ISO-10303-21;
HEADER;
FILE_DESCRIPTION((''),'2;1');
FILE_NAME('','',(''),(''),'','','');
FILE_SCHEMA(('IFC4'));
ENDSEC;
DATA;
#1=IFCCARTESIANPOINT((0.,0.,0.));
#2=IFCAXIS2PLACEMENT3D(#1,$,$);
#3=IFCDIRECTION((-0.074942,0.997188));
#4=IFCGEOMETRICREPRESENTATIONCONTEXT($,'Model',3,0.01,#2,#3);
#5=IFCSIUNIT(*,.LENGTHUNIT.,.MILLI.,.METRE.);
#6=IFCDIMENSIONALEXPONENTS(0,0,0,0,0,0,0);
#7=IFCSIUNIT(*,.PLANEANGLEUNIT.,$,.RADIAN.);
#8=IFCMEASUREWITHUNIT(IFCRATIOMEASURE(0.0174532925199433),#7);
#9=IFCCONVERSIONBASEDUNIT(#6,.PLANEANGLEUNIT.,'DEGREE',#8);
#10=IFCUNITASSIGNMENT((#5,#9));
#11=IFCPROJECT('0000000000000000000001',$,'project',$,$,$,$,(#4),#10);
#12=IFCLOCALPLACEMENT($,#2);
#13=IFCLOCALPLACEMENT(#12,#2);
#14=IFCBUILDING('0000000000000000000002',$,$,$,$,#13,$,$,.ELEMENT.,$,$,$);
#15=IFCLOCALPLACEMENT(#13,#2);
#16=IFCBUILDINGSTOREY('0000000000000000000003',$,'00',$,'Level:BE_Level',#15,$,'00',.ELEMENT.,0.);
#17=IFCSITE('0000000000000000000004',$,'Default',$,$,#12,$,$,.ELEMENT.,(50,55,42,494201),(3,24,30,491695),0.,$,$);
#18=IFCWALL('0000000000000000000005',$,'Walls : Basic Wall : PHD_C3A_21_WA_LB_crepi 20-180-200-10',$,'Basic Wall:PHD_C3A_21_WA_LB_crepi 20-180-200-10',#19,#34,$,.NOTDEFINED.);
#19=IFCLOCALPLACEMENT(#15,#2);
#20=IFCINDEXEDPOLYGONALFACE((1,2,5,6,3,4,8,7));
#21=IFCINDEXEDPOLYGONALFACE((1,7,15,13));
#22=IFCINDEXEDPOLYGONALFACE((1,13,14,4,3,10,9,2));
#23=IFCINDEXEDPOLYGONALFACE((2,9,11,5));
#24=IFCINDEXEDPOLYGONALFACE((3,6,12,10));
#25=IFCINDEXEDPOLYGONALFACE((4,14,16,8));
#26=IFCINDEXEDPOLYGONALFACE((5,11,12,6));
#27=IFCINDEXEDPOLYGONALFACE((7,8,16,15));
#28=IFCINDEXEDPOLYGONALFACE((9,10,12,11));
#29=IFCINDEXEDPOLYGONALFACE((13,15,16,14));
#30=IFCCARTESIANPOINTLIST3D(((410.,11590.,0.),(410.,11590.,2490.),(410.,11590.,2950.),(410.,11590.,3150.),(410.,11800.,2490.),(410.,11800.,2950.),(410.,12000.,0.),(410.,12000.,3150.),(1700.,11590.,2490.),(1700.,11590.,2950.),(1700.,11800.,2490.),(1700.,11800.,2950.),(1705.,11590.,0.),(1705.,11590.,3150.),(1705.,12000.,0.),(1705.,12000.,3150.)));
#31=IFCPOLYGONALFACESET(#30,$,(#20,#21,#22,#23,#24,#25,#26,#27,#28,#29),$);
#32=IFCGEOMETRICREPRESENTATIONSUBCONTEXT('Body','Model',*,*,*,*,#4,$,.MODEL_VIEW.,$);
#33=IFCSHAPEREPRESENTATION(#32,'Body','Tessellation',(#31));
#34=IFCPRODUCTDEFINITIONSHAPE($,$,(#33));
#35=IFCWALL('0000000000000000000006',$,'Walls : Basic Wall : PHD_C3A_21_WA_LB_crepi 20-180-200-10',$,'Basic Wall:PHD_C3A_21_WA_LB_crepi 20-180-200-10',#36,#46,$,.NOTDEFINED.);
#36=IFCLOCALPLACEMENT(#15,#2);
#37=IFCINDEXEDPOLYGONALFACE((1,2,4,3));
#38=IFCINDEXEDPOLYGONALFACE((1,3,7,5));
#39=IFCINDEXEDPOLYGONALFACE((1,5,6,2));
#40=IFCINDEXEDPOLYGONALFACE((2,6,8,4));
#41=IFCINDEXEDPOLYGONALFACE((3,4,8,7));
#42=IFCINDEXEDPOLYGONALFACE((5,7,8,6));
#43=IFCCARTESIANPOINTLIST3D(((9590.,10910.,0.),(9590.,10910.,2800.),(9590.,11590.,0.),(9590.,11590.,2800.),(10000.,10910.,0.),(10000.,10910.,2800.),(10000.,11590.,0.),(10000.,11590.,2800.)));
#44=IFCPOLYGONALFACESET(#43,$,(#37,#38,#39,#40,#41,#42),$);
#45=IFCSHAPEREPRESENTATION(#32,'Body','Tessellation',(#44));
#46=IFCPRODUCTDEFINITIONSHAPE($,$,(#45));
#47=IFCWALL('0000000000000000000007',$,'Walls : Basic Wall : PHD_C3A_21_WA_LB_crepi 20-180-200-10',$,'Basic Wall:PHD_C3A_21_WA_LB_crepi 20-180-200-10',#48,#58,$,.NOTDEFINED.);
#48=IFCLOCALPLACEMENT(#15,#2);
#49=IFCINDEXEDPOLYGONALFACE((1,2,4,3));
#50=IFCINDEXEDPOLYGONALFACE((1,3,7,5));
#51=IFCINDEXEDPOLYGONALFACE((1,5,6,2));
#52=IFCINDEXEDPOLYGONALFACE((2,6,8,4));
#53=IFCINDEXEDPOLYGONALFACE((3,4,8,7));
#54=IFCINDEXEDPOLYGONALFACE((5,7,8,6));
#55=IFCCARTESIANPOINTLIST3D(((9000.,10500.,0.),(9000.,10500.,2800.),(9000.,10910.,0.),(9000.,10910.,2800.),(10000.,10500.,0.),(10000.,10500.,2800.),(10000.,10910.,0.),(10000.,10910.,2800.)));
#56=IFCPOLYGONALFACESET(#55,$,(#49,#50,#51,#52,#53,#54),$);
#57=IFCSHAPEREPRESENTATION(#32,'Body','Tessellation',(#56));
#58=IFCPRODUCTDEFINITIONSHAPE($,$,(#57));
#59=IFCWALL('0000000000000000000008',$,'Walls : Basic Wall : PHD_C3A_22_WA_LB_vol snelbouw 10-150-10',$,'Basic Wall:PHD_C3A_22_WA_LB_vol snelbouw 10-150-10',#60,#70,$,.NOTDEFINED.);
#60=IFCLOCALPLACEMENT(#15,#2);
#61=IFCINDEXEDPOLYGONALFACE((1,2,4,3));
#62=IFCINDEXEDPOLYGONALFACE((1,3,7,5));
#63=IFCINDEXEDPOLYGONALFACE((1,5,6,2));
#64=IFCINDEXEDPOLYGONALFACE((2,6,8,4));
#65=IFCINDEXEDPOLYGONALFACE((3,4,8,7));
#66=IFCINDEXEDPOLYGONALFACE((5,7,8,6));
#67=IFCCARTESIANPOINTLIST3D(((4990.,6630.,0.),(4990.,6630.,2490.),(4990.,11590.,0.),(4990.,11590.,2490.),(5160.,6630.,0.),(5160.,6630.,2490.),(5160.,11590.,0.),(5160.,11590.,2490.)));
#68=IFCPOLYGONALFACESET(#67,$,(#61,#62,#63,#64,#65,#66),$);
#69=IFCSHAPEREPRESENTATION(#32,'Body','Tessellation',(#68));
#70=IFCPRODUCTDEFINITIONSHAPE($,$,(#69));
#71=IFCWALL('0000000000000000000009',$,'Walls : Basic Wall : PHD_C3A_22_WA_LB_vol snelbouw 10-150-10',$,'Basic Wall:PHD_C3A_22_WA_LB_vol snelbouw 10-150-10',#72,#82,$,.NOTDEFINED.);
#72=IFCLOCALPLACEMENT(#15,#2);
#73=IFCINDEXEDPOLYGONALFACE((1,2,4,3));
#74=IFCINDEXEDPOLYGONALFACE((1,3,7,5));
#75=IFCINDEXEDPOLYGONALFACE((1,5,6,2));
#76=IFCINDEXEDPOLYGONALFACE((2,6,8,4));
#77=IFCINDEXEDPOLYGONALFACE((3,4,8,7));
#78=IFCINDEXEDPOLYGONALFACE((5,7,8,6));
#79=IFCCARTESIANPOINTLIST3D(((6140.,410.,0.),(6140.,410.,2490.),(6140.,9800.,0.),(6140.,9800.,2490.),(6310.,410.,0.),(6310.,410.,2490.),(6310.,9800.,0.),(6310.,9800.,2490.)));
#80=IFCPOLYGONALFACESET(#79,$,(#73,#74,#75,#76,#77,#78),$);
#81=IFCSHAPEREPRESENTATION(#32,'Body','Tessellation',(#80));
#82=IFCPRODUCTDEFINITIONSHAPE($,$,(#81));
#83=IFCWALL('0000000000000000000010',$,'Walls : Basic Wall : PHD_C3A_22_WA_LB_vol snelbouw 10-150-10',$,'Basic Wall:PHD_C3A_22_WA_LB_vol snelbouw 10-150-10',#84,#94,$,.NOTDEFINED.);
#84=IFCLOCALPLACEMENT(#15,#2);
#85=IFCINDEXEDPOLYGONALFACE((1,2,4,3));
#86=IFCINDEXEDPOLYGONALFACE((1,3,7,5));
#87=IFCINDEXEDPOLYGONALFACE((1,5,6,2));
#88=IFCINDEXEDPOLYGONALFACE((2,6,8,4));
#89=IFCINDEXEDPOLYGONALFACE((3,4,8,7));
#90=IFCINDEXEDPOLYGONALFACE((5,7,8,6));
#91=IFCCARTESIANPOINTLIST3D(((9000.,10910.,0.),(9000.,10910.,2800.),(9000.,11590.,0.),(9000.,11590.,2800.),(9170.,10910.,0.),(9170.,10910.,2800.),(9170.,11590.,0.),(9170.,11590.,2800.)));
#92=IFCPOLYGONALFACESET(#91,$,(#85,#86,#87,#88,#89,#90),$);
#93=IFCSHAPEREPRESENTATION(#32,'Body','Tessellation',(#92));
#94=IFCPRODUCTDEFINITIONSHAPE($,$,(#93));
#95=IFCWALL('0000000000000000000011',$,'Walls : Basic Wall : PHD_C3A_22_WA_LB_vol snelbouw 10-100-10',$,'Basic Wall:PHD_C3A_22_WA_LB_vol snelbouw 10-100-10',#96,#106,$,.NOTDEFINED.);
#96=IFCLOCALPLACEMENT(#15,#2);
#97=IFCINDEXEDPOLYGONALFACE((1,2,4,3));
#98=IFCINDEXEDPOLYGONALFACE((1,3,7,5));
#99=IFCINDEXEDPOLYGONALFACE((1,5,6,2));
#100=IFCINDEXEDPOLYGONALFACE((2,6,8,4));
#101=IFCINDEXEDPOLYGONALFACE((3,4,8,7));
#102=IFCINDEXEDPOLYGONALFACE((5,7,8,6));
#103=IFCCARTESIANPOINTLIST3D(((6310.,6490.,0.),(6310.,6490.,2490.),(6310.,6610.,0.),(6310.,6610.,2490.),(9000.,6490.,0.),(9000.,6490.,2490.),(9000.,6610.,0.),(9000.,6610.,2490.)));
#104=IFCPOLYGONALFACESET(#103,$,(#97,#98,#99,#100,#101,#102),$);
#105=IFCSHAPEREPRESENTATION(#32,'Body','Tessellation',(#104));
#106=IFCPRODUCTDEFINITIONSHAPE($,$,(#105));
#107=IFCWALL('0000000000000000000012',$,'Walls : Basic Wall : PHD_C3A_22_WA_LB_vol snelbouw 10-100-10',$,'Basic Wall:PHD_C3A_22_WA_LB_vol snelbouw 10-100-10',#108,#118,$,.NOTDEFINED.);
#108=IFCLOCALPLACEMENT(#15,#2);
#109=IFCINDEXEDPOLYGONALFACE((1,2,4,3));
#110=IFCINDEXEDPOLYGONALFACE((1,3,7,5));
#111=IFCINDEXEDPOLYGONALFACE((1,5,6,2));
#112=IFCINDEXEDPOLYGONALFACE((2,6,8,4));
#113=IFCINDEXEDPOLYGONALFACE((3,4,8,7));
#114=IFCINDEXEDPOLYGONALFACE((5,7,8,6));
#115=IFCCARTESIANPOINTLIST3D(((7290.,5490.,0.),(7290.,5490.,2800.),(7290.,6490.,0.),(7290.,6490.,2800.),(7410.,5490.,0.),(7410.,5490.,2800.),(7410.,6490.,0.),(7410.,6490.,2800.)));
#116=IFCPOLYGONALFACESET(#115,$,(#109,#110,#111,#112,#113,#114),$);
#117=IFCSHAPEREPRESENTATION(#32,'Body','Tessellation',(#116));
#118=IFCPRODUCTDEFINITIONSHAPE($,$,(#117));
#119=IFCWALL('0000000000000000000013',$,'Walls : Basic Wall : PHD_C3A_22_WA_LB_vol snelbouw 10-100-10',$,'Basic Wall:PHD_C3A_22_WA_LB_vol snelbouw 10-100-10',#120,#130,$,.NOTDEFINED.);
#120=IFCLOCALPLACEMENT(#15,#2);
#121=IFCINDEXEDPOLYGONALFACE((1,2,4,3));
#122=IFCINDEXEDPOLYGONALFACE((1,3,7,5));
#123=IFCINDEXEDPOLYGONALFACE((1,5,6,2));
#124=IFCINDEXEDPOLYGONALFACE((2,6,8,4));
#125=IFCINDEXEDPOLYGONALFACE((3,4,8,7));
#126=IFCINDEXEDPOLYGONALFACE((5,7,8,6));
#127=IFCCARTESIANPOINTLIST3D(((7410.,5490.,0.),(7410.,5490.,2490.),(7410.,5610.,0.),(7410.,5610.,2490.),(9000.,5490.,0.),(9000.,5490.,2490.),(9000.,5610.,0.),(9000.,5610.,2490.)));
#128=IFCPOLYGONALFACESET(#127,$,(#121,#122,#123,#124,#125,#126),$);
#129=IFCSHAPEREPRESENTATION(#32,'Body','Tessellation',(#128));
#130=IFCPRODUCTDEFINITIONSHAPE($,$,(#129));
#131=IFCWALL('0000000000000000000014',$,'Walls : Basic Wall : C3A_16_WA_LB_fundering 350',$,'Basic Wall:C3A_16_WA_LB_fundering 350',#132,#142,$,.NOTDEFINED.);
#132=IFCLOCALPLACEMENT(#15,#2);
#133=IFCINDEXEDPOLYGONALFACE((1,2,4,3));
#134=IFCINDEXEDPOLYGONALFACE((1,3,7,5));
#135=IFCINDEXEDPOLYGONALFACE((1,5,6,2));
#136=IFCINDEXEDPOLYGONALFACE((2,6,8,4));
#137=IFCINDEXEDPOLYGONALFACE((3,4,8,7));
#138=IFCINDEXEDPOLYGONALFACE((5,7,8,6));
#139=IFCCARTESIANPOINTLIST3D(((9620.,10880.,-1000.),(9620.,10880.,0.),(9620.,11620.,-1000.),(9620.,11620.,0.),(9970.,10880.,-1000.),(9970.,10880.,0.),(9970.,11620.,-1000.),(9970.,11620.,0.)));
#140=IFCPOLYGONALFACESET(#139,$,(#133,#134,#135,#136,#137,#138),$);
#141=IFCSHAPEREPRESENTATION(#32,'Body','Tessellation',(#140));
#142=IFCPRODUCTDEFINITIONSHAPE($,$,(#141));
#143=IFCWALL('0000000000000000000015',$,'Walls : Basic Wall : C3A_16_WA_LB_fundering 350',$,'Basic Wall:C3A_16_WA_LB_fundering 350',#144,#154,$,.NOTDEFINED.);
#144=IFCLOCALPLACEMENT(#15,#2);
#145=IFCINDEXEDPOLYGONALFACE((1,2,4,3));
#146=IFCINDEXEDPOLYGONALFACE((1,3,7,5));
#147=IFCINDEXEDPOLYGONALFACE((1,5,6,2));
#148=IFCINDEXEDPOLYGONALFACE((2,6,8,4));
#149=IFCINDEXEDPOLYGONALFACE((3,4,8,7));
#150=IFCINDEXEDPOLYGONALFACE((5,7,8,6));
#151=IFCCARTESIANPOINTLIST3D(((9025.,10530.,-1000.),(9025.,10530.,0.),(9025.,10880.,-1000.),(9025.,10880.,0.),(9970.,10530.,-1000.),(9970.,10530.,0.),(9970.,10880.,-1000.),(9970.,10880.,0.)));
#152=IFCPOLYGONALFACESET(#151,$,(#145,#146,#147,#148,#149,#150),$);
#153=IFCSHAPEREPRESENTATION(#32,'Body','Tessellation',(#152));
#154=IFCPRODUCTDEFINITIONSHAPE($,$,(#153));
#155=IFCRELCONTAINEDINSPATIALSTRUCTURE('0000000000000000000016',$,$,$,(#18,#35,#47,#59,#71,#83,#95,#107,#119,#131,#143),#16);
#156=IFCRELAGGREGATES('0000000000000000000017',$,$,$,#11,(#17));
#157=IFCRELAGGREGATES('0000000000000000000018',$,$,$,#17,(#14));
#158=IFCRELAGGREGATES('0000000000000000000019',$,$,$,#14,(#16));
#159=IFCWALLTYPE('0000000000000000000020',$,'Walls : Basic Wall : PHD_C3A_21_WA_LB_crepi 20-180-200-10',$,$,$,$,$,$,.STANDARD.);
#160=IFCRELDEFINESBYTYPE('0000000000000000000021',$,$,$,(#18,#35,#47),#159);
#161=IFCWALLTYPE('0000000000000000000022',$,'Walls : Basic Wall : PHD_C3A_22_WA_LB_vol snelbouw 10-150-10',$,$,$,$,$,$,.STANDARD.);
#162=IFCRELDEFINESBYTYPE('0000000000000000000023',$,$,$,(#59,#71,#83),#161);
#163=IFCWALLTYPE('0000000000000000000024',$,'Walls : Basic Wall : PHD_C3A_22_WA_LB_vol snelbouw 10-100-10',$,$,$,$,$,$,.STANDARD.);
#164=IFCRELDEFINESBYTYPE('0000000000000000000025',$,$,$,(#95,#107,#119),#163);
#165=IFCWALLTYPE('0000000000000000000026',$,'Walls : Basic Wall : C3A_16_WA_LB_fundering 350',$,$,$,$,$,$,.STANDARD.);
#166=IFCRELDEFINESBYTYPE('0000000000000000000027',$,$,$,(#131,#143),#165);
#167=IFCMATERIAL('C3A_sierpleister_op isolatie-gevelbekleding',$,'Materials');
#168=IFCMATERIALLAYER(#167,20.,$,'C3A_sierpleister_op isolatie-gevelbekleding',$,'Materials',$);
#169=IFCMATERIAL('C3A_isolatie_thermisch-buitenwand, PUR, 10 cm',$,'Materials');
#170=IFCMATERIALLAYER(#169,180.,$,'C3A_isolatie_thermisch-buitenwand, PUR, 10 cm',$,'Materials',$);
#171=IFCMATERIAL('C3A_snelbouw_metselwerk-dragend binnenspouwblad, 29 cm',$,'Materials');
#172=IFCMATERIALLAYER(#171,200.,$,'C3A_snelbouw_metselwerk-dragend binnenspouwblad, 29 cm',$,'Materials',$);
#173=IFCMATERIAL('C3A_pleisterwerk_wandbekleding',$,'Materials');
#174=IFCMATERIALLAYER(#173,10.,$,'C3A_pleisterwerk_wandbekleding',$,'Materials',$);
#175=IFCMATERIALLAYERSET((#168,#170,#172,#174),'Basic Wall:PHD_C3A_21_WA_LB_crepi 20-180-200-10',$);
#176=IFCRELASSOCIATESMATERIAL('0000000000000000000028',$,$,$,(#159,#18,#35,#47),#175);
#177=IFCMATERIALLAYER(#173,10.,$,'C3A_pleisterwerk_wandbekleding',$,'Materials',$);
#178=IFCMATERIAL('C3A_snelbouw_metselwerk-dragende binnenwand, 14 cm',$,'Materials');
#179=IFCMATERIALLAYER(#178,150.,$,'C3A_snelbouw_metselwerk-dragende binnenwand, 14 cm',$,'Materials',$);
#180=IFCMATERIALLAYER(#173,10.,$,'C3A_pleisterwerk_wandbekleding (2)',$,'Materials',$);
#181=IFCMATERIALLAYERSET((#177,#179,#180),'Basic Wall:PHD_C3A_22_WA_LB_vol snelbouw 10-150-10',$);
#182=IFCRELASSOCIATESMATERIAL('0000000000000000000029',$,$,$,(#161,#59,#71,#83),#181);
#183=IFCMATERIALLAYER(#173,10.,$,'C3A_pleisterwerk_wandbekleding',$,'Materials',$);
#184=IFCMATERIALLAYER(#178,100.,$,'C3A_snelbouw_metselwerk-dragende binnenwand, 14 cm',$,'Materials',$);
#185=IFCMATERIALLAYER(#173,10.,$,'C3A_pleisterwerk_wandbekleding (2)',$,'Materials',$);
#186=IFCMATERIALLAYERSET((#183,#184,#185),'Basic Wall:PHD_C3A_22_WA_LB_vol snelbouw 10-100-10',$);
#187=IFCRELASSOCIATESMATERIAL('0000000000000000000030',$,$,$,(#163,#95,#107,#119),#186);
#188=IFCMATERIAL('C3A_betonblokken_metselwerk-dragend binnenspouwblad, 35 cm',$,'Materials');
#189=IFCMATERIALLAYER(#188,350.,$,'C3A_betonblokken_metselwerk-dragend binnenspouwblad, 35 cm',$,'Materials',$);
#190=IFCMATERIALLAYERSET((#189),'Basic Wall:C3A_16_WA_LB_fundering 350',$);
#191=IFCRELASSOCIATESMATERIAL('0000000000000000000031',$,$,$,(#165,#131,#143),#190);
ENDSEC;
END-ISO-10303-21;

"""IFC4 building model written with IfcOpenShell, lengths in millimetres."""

from ifc_helpers import new_model, entity, si_unit, converted_unit, direction, frame, frame_2d, origin, place, context, subcontext, project, spatial, polyline, rectangle, extrude, clip, bounded_halfspace, material, layer, layer_set, layer_usage, type_object, element, save


model = new_model("IFC4")

# Units and contexts
model_context = context("Model", 3, precision=0.01, world=origin(), true_north=direction((-0.074942, 0.997188)))
body_context = subcontext(model_context, "Body", "Model", "MODEL_VIEW")
ifc_project = project(units=[si_unit("LENGTHUNIT", "METRE", prefix="MILLI"), converted_unit("PLANEANGLEUNIT", "DEGREE", entity("IfcRatioMeasure", 0.0174532925199433), si_unit("PLANEANGLEUNIT", "RADIAN"), dimensions=[0, 0, 0, 0, 0, 0, 0])], contexts=[model_context])

# Site, building, storey
site_placement = place(None, origin())
site = spatial("IfcSite", under=ifc_project, at=site_placement, Name="Default", CompositionType="ELEMENT", RefLatitude=(50, 55, 42, 494201), RefLongitude=(3, 24, 30, 491695), RefElevation=0.0)
building_placement = place(site_placement, origin())
building = spatial("IfcBuilding", under=site, at=building_placement, CompositionType="ELEMENT")
storey_placement = place(building_placement, frame((0.0, 0.0, 0.0)))
storey = spatial("IfcBuildingStorey", under=building, at=storey_placement, Name="00", ObjectType="Level:BE_Level", LongName="00", CompositionType="ELEMENT", Elevation=0.0)

# Wall, opening
ifc_material_1 = material(Name="C3A_sierpleister_op isolatie-gevelbekleding", Category="Materials")
ifc_layer_1 = layer(ifc_material_1, 20.0, Name="C3A_sierpleister_op isolatie-gevelbekleding", Category="Materials")
ifc_material_2 = material(Name="C3A_isolatie_thermisch-buitenwand, PUR, 10 cm", Category="Materials")
ifc_layer_2 = layer(ifc_material_2, 180.0, Name="C3A_isolatie_thermisch-buitenwand, PUR, 10 cm", Category="Materials")
ifc_material_3 = material(Name="C3A_snelbouw_metselwerk-dragend binnenspouwblad, 29 cm", Category="Materials")
ifc_layer_3 = layer(ifc_material_3, 200.0, Name="C3A_snelbouw_metselwerk-dragend binnenspouwblad, 29 cm", Category="Materials")
ifc_material_4 = material(Name="C3A_pleisterwerk_wandbekleding", Category="Materials")
ifc_layer_4 = layer(ifc_material_4, 10.0, Name="C3A_pleisterwerk_wandbekleding", Category="Materials")
ifc_layer_set_1 = layer_set([ifc_layer_1, ifc_layer_2, ifc_layer_3, ifc_layer_4], Name="Basic Wall:PHD_C3A_21_WA_LB_crepi 20-180-200-10")
ifc_layer_usage_1 = layer_usage(ifc_layer_set_1, "AXIS2", "NEGATIVE", 205.0)
wall_type_1 = type_object("IfcWallType", Name="Walls : Basic Wall : PHD_C3A_21_WA_LB_crepi 20-180-200-10", PredefinedType="STANDARD", material=ifc_layer_set_1)
wall_1_placement = place(storey_placement, frame((410.0, 11795.0, 0.0)))
wall_1 = element("IfcWall", 1, at=wall_1_placement, inside=storey, type_object=wall_type_1, material=ifc_layer_usage_1, Name="Walls : Basic Wall : PHD_C3A_21_WA_LB_crepi 20-180-200-10", ObjectType="Basic Wall:PHD_C3A_21_WA_LB_crepi 20-180-200-10", PredefinedType="NOTDEFINED", context=body_context, shape_type="SweptSolid", body=[
    extrude(rectangle(XDim=1295.0, YDim=410.0, at=frame_2d((647.5, 0.0), x_axis=(-1.0, 0.0))), origin(), (0.0, 0.0, 1.0), 3150.0),
])
opening_placement = place(storey_placement, frame((410.0, 11795.0, 0.0)))
element("IfcOpeningElement", 2, at=opening_placement, cuts=wall_1, PredefinedType="OPENING", context=body_context, shape_type="SweptSolid", body=[
    extrude(rectangle(XDim=210.0, YDim=1290.0, at=frame_2d((0.0, 0.0), x_axis=(1.0, 0.0))), frame((645.0, -100.0, 2490.0), z_axis=(0.0, 0.0, 1.0), x_axis=(0.0, 1.0, 0.0)), (0.0, 0.0, 1.0), 460.0),
])

# Walls
ifc_layer_usage_2 = layer_usage(ifc_layer_set_1, "AXIS2", "NEGATIVE", 205.0)
wall_2_placement = place(storey_placement, frame((9795.0, 11590.0, 0.0), z_axis=(0.0, 0.0, 1.0), x_axis=(0.0, -1.0, 0.0)))
element("IfcWall", 3, at=wall_2_placement, inside=storey, type_object=wall_type_1, material=ifc_layer_usage_2, Name="Walls : Basic Wall : PHD_C3A_21_WA_LB_crepi 20-180-200-10", ObjectType="Basic Wall:PHD_C3A_21_WA_LB_crepi 20-180-200-10", PredefinedType="NOTDEFINED", context=body_context, shape_type="SweptSolid", body=[
    extrude(rectangle(XDim=680.0, YDim=410.0, at=frame_2d((340.0, 0.0), x_axis=(-1.0, 0.0))), origin(), (0.0, 0.0, 1.0), 2800.0),
])
ifc_layer_usage_3 = layer_usage(ifc_layer_set_1, "AXIS2", "NEGATIVE", 205.0)
wall_3_placement = place(storey_placement, frame((10000.0, 10705.0, 0.0), z_axis=(0.0, 0.0, 1.0), x_axis=(-1.0, 0.0, 0.0)))
element("IfcWall", 4, at=wall_3_placement, inside=storey, type_object=wall_type_1, material=ifc_layer_usage_3, Name="Walls : Basic Wall : PHD_C3A_21_WA_LB_crepi 20-180-200-10", ObjectType="Basic Wall:PHD_C3A_21_WA_LB_crepi 20-180-200-10", PredefinedType="NOTDEFINED", context=body_context, shape_type="SweptSolid", body=[
    extrude(rectangle(XDim=1000.0, YDim=410.0, at=frame_2d((500.0, 0.0), x_axis=(-1.0, 0.0))), origin(), (0.0, 0.0, 1.0), 2800.0),
])
ifc_layer_5 = layer(ifc_material_4, 10.0, Name="C3A_pleisterwerk_wandbekleding", Category="Materials")
ifc_material_5 = material(Name="C3A_snelbouw_metselwerk-dragende binnenwand, 14 cm", Category="Materials")
ifc_layer_6 = layer(ifc_material_5, 150.0, Name="C3A_snelbouw_metselwerk-dragende binnenwand, 14 cm", Category="Materials")
ifc_layer_7 = layer(ifc_material_4, 10.0, Name="C3A_pleisterwerk_wandbekleding (2)", Category="Materials")
ifc_layer_set_2 = layer_set([ifc_layer_5, ifc_layer_6, ifc_layer_7], Name="Basic Wall:PHD_C3A_22_WA_LB_vol snelbouw 10-150-10")
ifc_layer_usage_4 = layer_usage(ifc_layer_set_2, "AXIS2", "NEGATIVE", 85.0)
wall_type_2 = type_object("IfcWallType", Name="Walls : Basic Wall : PHD_C3A_22_WA_LB_vol snelbouw 10-150-10", PredefinedType="STANDARD", material=ifc_layer_set_2)
wall_4_placement = place(storey_placement, frame((5075.0, 11590.0, 0.0), z_axis=(0.0, 0.0, 1.0), x_axis=(0.0, -1.0, 0.0)))
element("IfcWall", 5, at=wall_4_placement, inside=storey, type_object=wall_type_2, material=ifc_layer_usage_4, Name="Walls : Basic Wall : PHD_C3A_22_WA_LB_vol snelbouw 10-150-10", ObjectType="Basic Wall:PHD_C3A_22_WA_LB_vol snelbouw 10-150-10", PredefinedType="NOTDEFINED", context=body_context, shape_type="Clipping", body=[
    clip(extrude(rectangle(XDim=4960.0, YDim=170.0, at=frame_2d((2480.0, 0.0), x_axis=(-1.0, 0.0))), origin(), (0.0, 0.0, 1.0), 2490.0), bounded_halfspace(frame((0.0, -85.0, 2490.0), z_axis=(0.0, 0.0, -1.0), x_axis=(1.0, 0.0, 0.0)), True, frame((0.0, -85.0, 2490.0), z_axis=(0.0, 0.0, -1.0), x_axis=(1.0, 0.0, 0.0)), polyline([(0.0, 0.0), (0.0, -170.0), (4960.0, -170.0), (4960.0, 0.0), (0.0, 0.0)]))),
])
ifc_layer_usage_5 = layer_usage(ifc_layer_set_2, "AXIS2", "NEGATIVE", 85.0)
wall_5_placement = place(storey_placement, frame((6225.0, 9800.0, 0.0), z_axis=(0.0, 0.0, 1.0), x_axis=(0.0, -1.0, 0.0)))
element("IfcWall", 6, at=wall_5_placement, inside=storey, type_object=wall_type_2, material=ifc_layer_usage_5, Name="Walls : Basic Wall : PHD_C3A_22_WA_LB_vol snelbouw 10-150-10", ObjectType="Basic Wall:PHD_C3A_22_WA_LB_vol snelbouw 10-150-10", PredefinedType="NOTDEFINED", context=body_context, shape_type="Clipping", body=[
    clip(extrude(rectangle(XDim=9390.0, YDim=170.0, at=frame_2d((4695.0, 0.0), x_axis=(-1.0, 0.0))), origin(), (0.0, 0.0, 1.0), 2490.0), bounded_halfspace(frame((0.0, -85.0, 2490.0), z_axis=(0.0, 0.0, -1.0), x_axis=(1.0, 0.0, 0.0)), True, frame((0.0, -85.0, 2490.0), z_axis=(0.0, 0.0, -1.0), x_axis=(1.0, 0.0, 0.0)), polyline([(0.0, 0.0), (0.0, -170.0), (3190.0, -170.0), (3310.0, -170.0), (6890.0, -170.0), (7060.0, -170.0), (9390.0, -170.0), (9390.0, 0.0), (0.0, 0.0)]))),
])
ifc_layer_usage_6 = layer_usage(ifc_layer_set_2, "AXIS2", "NEGATIVE", 85.0)
wall_6_placement = place(storey_placement, frame((9085.0, 11590.0, 0.0), z_axis=(0.0, 0.0, 1.0), x_axis=(0.0, -1.0, 0.0)))
element("IfcWall", 7, at=wall_6_placement, inside=storey, type_object=wall_type_2, material=ifc_layer_usage_6, Name="Walls : Basic Wall : PHD_C3A_22_WA_LB_vol snelbouw 10-150-10", ObjectType="Basic Wall:PHD_C3A_22_WA_LB_vol snelbouw 10-150-10", PredefinedType="NOTDEFINED", context=body_context, shape_type="SweptSolid", body=[
    extrude(rectangle(XDim=680.0, YDim=170.0, at=frame_2d((340.0, 0.0), x_axis=(-1.0, 0.0))), origin(), (0.0, 0.0, 1.0), 2800.0),
])
ifc_layer_8 = layer(ifc_material_4, 10.0, Name="C3A_pleisterwerk_wandbekleding", Category="Materials")
ifc_layer_9 = layer(ifc_material_5, 100.0, Name="C3A_snelbouw_metselwerk-dragende binnenwand, 14 cm", Category="Materials")
ifc_layer_10 = layer(ifc_material_4, 10.0, Name="C3A_pleisterwerk_wandbekleding (2)", Category="Materials")
ifc_layer_set_3 = layer_set([ifc_layer_8, ifc_layer_9, ifc_layer_10], Name="Basic Wall:PHD_C3A_22_WA_LB_vol snelbouw 10-100-10")
ifc_layer_usage_7 = layer_usage(ifc_layer_set_3, "AXIS2", "NEGATIVE", 60.0)
wall_type_3 = type_object("IfcWallType", Name="Walls : Basic Wall : PHD_C3A_22_WA_LB_vol snelbouw 10-100-10", PredefinedType="STANDARD", material=ifc_layer_set_3)
wall_7_placement = place(storey_placement, frame((9000.0, 6550.0, 0.0), z_axis=(0.0, 0.0, 1.0), x_axis=(-1.0, 0.0, 0.0)))
element("IfcWall", 8, at=wall_7_placement, inside=storey, type_object=wall_type_3, material=ifc_layer_usage_7, Name="Walls : Basic Wall : PHD_C3A_22_WA_LB_vol snelbouw 10-100-10", ObjectType="Basic Wall:PHD_C3A_22_WA_LB_vol snelbouw 10-100-10", PredefinedType="NOTDEFINED", context=body_context, shape_type="Clipping", body=[
    clip(extrude(rectangle(XDim=2690.0, YDim=120.0, at=frame_2d((1345.0, 0.0), x_axis=(-1.0, 0.0))), origin(), (0.0, 0.0, 1.0), 2490.0), bounded_halfspace(frame((0.0, -60.0, 2490.0), z_axis=(0.0, 0.0, -1.0), x_axis=(0.0, 1.0, 0.0)), True, frame((0.0, -60.0, 2490.0), z_axis=(0.0, 0.0, -1.0), x_axis=(0.0, 1.0, 0.0)), polyline([(0.0, 0.0), (120.0, 0.0), (120.0, 2690.0), (0.0, 2690.0), (0.0, 0.0)]))),
])
ifc_layer_usage_8 = layer_usage(ifc_layer_set_3, "AXIS2", "NEGATIVE", 60.0)
wall_8_placement = place(storey_placement, frame((7350.0, 6490.0, 0.0), z_axis=(0.0, 0.0, 1.0), x_axis=(0.0, -1.0, 0.0)))
element("IfcWall", 9, at=wall_8_placement, inside=storey, type_object=wall_type_3, material=ifc_layer_usage_8, Name="Walls : Basic Wall : PHD_C3A_22_WA_LB_vol snelbouw 10-100-10", ObjectType="Basic Wall:PHD_C3A_22_WA_LB_vol snelbouw 10-100-10", PredefinedType="NOTDEFINED", context=body_context, shape_type="SweptSolid", body=[
    extrude(rectangle(XDim=1000.0, YDim=120.0, at=frame_2d((500.0, 0.0), x_axis=(-1.0, 0.0))), origin(), (0.0, 0.0, 1.0), 2800.0),
])
ifc_layer_usage_9 = layer_usage(ifc_layer_set_3, "AXIS2", "NEGATIVE", 60.0)
wall_9_placement = place(storey_placement, frame((9000.0, 5550.0, 0.0), z_axis=(0.0, 0.0, 1.0), x_axis=(-1.0, 0.0, 0.0)))
element("IfcWall", 10, at=wall_9_placement, inside=storey, type_object=wall_type_3, material=ifc_layer_usage_9, Name="Walls : Basic Wall : PHD_C3A_22_WA_LB_vol snelbouw 10-100-10", ObjectType="Basic Wall:PHD_C3A_22_WA_LB_vol snelbouw 10-100-10", PredefinedType="NOTDEFINED", context=body_context, shape_type="Clipping", body=[
    clip(extrude(rectangle(XDim=1590.0, YDim=120.0, at=frame_2d((795.0, 0.0), x_axis=(-1.0, 0.0))), origin(), (0.0, 0.0, 1.0), 2490.0), bounded_halfspace(frame((0.0, -60.0, 2490.0), z_axis=(0.0, 0.0, -1.0), x_axis=(0.0, 1.0, 0.0)), True, frame((0.0, -60.0, 2490.0), z_axis=(0.0, 0.0, -1.0), x_axis=(0.0, 1.0, 0.0)), polyline([(0.0, 0.0), (120.0, 0.0), (120.0, 1590.0), (0.0, 1590.0), (0.0, 0.0)]))),
])
ifc_material_6 = material(Name="C3A_betonblokken_metselwerk-dragend binnenspouwblad, 35 cm", Category="Materials")
ifc_layer_11 = layer(ifc_material_6, 350.0, Name="C3A_betonblokken_metselwerk-dragend binnenspouwblad, 35 cm", Category="Materials")
ifc_layer_set_4 = layer_set([ifc_layer_11], Name="Basic Wall:C3A_16_WA_LB_fundering 350")
ifc_layer_usage_10 = layer_usage(ifc_layer_set_4, "AXIS2", "NEGATIVE", 175.0)
wall_type_4 = type_object("IfcWallType", Name="Walls : Basic Wall : C3A_16_WA_LB_fundering 350", PredefinedType="STANDARD", material=ifc_layer_set_4)
wall_10_placement = place(storey_placement, frame((9795.0, 11620.0, -1000.0), z_axis=(0.0, 0.0, 1.0), x_axis=(0.0, -1.0, 0.0)))
element("IfcWall", 11, at=wall_10_placement, inside=storey, type_object=wall_type_4, material=ifc_layer_usage_10, Name="Walls : Basic Wall : C3A_16_WA_LB_fundering 350", ObjectType="Basic Wall:C3A_16_WA_LB_fundering 350", PredefinedType="NOTDEFINED", context=body_context, shape_type="SweptSolid", body=[
    extrude(rectangle(XDim=740.0, YDim=350.0, at=frame_2d((370.0, 0.0), x_axis=(-1.0, 0.0))), origin(), (0.0, 0.0, 1.0), 1000.0),
])
ifc_layer_usage_11 = layer_usage(ifc_layer_set_4, "AXIS2", "NEGATIVE", 175.0)
wall_11_placement = place(storey_placement, frame((9970.0, 10705.0, -1000.0), z_axis=(0.0, 0.0, 1.0), x_axis=(-1.0, 0.0, 0.0)))
element("IfcWall", 12, at=wall_11_placement, inside=storey, type_object=wall_type_4, material=ifc_layer_usage_11, Name="Walls : Basic Wall : C3A_16_WA_LB_fundering 350", ObjectType="Basic Wall:C3A_16_WA_LB_fundering 350", PredefinedType="NOTDEFINED", context=body_context, shape_type="SweptSolid", body=[
    extrude(rectangle(XDim=945.0, YDim=350.0, at=frame_2d((472.5, 0.0), x_axis=(-1.0, 0.0))), origin(), (0.0, 0.0, 1.0), 1000.0),
])

save(model, "model.ifc")
